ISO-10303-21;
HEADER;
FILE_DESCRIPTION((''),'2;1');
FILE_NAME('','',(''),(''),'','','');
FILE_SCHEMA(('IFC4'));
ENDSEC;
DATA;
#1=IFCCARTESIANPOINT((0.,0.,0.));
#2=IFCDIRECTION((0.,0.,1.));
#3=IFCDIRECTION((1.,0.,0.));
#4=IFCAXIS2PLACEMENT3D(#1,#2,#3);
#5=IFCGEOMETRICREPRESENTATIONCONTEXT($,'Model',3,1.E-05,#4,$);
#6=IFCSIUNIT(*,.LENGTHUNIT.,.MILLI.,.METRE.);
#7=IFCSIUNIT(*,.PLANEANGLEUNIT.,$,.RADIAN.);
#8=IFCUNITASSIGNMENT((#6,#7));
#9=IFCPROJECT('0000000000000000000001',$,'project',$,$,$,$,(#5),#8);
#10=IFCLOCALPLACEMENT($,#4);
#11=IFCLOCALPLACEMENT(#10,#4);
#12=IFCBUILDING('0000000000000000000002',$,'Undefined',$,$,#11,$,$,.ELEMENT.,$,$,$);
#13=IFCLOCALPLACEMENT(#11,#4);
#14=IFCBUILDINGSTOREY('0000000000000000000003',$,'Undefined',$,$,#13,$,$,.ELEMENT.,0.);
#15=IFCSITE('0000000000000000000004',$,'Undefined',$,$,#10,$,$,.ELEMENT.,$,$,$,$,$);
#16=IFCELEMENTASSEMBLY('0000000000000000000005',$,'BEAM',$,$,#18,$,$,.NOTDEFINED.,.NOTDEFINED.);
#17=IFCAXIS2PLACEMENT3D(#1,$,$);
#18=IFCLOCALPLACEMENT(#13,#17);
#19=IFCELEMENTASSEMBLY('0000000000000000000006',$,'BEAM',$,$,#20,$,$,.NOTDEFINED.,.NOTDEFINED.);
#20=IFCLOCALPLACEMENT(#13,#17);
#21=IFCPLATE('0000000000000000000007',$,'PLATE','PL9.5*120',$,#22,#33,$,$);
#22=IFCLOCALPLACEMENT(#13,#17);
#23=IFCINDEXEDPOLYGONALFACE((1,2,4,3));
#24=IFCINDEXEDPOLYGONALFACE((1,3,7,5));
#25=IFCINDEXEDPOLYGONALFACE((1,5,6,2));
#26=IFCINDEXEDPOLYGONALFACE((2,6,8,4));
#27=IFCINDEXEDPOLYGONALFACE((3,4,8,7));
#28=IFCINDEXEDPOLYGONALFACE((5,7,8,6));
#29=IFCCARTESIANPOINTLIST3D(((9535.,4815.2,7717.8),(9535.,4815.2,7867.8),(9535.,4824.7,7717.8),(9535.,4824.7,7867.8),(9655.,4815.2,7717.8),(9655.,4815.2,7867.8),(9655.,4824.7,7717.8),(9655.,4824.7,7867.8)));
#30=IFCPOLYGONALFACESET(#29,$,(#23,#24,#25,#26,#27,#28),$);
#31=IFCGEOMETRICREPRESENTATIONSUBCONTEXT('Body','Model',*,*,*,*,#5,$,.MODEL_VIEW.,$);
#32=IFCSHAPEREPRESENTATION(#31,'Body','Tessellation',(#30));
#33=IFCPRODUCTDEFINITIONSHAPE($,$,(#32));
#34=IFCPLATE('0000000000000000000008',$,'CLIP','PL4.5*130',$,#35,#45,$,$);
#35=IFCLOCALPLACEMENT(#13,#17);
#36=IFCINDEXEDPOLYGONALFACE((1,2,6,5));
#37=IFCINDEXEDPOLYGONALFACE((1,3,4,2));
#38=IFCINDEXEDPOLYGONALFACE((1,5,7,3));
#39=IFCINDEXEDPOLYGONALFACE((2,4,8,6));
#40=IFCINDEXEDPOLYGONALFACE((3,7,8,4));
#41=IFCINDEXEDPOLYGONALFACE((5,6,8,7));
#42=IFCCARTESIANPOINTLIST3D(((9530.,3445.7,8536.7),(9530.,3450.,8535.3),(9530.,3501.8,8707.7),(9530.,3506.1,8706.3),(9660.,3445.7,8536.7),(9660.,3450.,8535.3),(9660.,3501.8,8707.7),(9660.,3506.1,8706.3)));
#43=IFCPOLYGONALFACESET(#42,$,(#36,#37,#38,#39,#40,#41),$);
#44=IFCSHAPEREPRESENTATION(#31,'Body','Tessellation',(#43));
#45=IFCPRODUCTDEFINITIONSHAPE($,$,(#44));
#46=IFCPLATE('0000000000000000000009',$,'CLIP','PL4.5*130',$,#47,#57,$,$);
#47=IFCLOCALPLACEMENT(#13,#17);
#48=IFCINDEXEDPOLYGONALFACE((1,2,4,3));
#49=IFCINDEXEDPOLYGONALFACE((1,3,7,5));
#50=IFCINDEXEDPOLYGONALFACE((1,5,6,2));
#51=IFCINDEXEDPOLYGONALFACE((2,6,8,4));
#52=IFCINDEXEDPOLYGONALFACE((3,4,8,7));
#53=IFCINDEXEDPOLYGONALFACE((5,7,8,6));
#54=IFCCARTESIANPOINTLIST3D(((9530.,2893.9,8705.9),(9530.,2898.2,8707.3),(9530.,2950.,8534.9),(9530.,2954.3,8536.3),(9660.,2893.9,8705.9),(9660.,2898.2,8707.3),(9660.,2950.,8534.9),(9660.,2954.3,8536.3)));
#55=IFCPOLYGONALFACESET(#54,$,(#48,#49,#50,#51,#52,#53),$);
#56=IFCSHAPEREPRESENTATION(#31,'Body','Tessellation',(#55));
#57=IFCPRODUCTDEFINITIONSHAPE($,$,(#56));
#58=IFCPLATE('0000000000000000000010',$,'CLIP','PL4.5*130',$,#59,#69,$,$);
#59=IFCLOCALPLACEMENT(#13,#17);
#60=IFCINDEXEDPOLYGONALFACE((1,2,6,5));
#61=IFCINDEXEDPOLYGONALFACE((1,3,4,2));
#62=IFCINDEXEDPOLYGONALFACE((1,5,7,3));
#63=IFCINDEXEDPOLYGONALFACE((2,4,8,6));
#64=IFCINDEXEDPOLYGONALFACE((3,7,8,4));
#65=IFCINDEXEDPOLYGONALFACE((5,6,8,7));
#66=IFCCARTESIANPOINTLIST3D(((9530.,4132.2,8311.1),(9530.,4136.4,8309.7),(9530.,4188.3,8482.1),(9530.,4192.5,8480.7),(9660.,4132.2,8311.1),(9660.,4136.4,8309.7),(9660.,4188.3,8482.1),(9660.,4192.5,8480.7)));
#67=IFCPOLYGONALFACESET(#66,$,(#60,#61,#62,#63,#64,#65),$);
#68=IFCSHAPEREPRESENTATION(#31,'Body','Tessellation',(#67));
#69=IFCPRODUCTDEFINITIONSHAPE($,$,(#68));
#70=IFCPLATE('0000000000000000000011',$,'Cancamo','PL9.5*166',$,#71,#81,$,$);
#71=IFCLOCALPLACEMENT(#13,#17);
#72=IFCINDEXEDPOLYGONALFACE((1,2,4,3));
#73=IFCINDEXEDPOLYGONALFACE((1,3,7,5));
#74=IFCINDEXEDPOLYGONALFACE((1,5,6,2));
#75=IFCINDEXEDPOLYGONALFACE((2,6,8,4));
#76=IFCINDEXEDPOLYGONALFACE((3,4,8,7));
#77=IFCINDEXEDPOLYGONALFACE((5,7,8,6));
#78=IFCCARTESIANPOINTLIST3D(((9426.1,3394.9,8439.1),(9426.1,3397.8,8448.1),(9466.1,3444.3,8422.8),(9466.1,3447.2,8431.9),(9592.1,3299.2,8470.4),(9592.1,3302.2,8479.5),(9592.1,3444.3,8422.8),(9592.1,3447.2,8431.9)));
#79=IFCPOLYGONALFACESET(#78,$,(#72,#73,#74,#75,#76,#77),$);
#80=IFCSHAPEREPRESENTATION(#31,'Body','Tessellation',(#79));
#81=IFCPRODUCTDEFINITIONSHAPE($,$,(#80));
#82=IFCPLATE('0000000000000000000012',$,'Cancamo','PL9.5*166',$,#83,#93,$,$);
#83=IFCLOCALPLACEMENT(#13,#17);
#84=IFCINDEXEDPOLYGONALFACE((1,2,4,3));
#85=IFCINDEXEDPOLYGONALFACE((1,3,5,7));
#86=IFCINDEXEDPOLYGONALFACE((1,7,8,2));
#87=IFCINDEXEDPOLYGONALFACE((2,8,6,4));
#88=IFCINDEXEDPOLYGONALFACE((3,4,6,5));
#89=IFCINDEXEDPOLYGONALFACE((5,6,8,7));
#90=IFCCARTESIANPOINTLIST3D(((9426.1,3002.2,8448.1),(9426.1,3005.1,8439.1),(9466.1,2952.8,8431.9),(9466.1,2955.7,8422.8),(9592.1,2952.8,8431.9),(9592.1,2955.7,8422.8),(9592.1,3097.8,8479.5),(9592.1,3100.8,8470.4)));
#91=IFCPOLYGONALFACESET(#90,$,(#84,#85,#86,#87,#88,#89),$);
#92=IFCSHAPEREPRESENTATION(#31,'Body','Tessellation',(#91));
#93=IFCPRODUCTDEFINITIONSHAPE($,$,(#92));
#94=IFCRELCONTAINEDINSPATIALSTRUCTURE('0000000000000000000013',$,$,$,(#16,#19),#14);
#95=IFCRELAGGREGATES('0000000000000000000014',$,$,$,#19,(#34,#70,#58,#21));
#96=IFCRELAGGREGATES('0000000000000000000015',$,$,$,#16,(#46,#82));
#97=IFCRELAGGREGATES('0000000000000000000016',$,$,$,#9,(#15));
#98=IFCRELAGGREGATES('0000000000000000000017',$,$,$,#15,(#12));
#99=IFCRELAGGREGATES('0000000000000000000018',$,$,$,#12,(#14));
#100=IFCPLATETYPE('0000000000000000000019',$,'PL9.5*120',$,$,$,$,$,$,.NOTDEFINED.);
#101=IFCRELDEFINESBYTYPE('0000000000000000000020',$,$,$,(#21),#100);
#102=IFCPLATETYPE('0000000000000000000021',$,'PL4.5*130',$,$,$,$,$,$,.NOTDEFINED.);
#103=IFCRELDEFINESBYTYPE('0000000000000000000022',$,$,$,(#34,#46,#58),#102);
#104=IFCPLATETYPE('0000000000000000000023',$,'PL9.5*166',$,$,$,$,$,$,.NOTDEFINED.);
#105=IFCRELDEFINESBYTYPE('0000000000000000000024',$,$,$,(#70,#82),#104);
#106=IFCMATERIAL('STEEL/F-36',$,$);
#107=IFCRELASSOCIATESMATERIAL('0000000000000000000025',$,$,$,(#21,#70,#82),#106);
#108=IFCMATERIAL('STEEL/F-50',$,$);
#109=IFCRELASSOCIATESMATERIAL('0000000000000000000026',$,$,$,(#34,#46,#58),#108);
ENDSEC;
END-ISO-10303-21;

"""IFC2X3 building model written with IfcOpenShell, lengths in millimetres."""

from ifc_helpers import new_model, si_unit, frame, origin_with_axes, place, context, subcontext, project, spatial, polyline, outline, extrude, material, type_object, element, aggregate, save


model = new_model("IFC2X3")

# Units and contexts
model_context = context("Model", 3, precision=1e-05, world=origin_with_axes())
body_context = subcontext(model_context, "Body", "Model", "MODEL_VIEW")
ifc_project = project(units=[si_unit("LENGTHUNIT", "METRE", prefix="MILLI"), si_unit("PLANEANGLEUNIT", "RADIAN")], contexts=[model_context])

# Site, building, storey
site_placement = place(None, origin_with_axes())
site = spatial("IfcSite", under=ifc_project, at=site_placement, Name="Undefined", CompositionType="ELEMENT")
building_placement = place(site_placement, origin_with_axes())
building = spatial("IfcBuilding", under=site, at=building_placement, Name="Undefined", CompositionType="ELEMENT")
storey_placement = place(building_placement, origin_with_axes())
storey = spatial("IfcBuildingStorey", under=building, at=storey_placement, Name="Undefined", CompositionType="ELEMENT", Elevation=0.0)

# Element assembly
assembly_1_placement = place(storey_placement, origin_with_axes())
assembly_1 = element("IfcElementAssembly", 1, at=assembly_1_placement, inside=storey, Name="BEAM", AssemblyPlace="NOTDEFINED", PredefinedType="NOTDEFINED")
ifc_material_1 = material(Name="STEEL/F-36")

# Element assembly
assembly_2_placement = place(storey_placement, origin_with_axes())
assembly_2 = element("IfcElementAssembly", 2, at=assembly_2_placement, inside=storey, Name="BEAM", AssemblyPlace="NOTDEFINED", PredefinedType="NOTDEFINED")

# Plates
plate_type_1 = type_object("IfcPlateType", Name="PL9.5*120", PredefinedType="NOTDEFINED")
plate_1_placement = place(assembly_2_placement, frame((9655.0, 4820.0, 7867.8), z_axis=(0.0, -1.0, 0.0), x_axis=(-1.0, 0.0, 0.0)))
plate_1 = element("IfcPlate", 3, at=plate_1_placement, type_object=plate_type_1, material=ifc_material_1, Name="PLATE", Description="PL9.5*120", context=body_context, shape_type="SweptSolid", body=[
    extrude(outline(polyline([(0.0, 0.0), (120.0, 0.0), (120.0, 150.0), (0.0, 150.0), (0.0, 0.0)])), frame((0.0, 0.0, -4.8), z_axis=(0.0, 0.0, 1.0), x_axis=(1.0, 0.0, 0.0)), (0.0, 0.0, 1.0), 9.5),
])
ifc_material_2 = material(Name="STEEL/F-50")
plate_type_2 = type_object("IfcPlateType", Name="PL4.5*130", PredefinedType="NOTDEFINED")
plate_2_placement = place(assembly_2_placement, frame((9530.0, 3504.0, 8707.0), z_axis=(0.0, -0.950157, 0.311771), x_axis=(0.0, -0.311771, -0.950157)))
plate_2 = element("IfcPlate", 4, at=plate_2_placement, type_object=plate_type_2, material=ifc_material_2, Name="CLIP", Description="PL4.5*130", context=body_context, shape_type="SweptSolid", body=[
    extrude(outline(polyline([(0.0, 0.0), (180.0, 0.0), (180.0, 130.0), (0.0, 130.0), (0.0, 0.0)])), frame((0.0, 0.0, -2.2), z_axis=(0.0, 0.0, 1.0), x_axis=(1.0, 0.0, 0.0)), (0.0, 0.0, 1.0), 4.5),
])
plate_3_placement = place(assembly_1_placement, frame((9660.0, 2896.0, 8706.6), z_axis=(0.0, 0.950157, 0.311771), x_axis=(0.0, 0.311771, -0.950157)))
plate_3 = element("IfcPlate", 5, at=plate_3_placement, type_object=plate_type_2, material=ifc_material_2, Name="CLIP", Description="PL4.5*130", context=body_context, shape_type="SweptSolid", body=[
    extrude(outline(polyline([(0.0, 0.0), (180.0, 0.0), (180.0, 130.0), (0.0, 130.0), (0.0, 0.0)])), frame((0.0, 0.0, -2.2), z_axis=(0.0, 0.0, 1.0), x_axis=(1.0, 0.0, 0.0)), (0.0, 0.0, 1.0), 4.5),
])
plate_4_placement = place(assembly_2_placement, frame((9530.0, 4190.4, 8481.4), z_axis=(0.0, -0.950157, 0.311771), x_axis=(0.0, -0.311771, -0.950157)))
plate_4 = element("IfcPlate", 6, at=plate_4_placement, type_object=plate_type_2, material=ifc_material_2, Name="CLIP", Description="PL4.5*130", context=body_context, shape_type="SweptSolid", body=[
    extrude(outline(polyline([(0.0, 0.0), (180.0, 0.0), (180.0, 130.0), (0.0, 130.0), (0.0, 0.0)])), frame((0.0, 0.0, -2.2), z_axis=(0.0, 0.0, 1.0), x_axis=(1.0, 0.0, 0.0)), (0.0, 0.0, 1.0), 4.5),
])
plate_type_3 = type_object("IfcPlateType", Name="PL9.5*166", PredefinedType="NOTDEFINED")
plate_5_placement = place(assembly_2_placement, frame((9592.1, 3300.7, 8475.0), z_axis=(0.00002, 0.311803, 0.950147), x_axis=(0.0, 0.950147, -0.311803)))
plate_5 = element("IfcPlate", 7, at=plate_5_placement, type_object=plate_type_3, material=ifc_material_1, Name="Cancamo", Description="PL9.5*166", context=body_context, shape_type="SweptSolid", body=[
    extrude(outline(polyline([(0.0, 0.0), (152.7, 0.0), (152.7, 126.0), (100.7, 166.0), (0.0, 0.0)])), frame((0.0, 0.0, -4.8), z_axis=(0.0, 0.0, 1.0), x_axis=(1.0, 0.0, 0.0)), (0.0, 0.0, 1.0), 9.5),
])
aggregate(assembly_2, [plate_2, plate_5, plate_4, plate_1])
plate_6_placement = place(assembly_1_placement, frame((9592.1, 2954.3, 8427.4), z_axis=(0.0, -0.311771, 0.950157), x_axis=(0.0, 0.950157, 0.311771)))
plate_6 = element("IfcPlate", 8, at=plate_6_placement, type_object=plate_type_3, material=ifc_material_1, Name="Cancamo", Description="PL9.5*166", context=body_context, shape_type="SweptSolid", body=[
    extrude(outline(polyline([(0.0, 0.0), (152.7, 0.0), (52.0, 166.0), (0.0, 126.0), (0.0, 0.0)])), frame((0.0, 0.0, -4.8), z_axis=(0.0, 0.0, 1.0), x_axis=(1.0, 0.0, 0.0)), (0.0, 0.0, 1.0), 9.5),
])

aggregate(assembly_1, [plate_3, plate_6])

save(model, "model.ifc")
